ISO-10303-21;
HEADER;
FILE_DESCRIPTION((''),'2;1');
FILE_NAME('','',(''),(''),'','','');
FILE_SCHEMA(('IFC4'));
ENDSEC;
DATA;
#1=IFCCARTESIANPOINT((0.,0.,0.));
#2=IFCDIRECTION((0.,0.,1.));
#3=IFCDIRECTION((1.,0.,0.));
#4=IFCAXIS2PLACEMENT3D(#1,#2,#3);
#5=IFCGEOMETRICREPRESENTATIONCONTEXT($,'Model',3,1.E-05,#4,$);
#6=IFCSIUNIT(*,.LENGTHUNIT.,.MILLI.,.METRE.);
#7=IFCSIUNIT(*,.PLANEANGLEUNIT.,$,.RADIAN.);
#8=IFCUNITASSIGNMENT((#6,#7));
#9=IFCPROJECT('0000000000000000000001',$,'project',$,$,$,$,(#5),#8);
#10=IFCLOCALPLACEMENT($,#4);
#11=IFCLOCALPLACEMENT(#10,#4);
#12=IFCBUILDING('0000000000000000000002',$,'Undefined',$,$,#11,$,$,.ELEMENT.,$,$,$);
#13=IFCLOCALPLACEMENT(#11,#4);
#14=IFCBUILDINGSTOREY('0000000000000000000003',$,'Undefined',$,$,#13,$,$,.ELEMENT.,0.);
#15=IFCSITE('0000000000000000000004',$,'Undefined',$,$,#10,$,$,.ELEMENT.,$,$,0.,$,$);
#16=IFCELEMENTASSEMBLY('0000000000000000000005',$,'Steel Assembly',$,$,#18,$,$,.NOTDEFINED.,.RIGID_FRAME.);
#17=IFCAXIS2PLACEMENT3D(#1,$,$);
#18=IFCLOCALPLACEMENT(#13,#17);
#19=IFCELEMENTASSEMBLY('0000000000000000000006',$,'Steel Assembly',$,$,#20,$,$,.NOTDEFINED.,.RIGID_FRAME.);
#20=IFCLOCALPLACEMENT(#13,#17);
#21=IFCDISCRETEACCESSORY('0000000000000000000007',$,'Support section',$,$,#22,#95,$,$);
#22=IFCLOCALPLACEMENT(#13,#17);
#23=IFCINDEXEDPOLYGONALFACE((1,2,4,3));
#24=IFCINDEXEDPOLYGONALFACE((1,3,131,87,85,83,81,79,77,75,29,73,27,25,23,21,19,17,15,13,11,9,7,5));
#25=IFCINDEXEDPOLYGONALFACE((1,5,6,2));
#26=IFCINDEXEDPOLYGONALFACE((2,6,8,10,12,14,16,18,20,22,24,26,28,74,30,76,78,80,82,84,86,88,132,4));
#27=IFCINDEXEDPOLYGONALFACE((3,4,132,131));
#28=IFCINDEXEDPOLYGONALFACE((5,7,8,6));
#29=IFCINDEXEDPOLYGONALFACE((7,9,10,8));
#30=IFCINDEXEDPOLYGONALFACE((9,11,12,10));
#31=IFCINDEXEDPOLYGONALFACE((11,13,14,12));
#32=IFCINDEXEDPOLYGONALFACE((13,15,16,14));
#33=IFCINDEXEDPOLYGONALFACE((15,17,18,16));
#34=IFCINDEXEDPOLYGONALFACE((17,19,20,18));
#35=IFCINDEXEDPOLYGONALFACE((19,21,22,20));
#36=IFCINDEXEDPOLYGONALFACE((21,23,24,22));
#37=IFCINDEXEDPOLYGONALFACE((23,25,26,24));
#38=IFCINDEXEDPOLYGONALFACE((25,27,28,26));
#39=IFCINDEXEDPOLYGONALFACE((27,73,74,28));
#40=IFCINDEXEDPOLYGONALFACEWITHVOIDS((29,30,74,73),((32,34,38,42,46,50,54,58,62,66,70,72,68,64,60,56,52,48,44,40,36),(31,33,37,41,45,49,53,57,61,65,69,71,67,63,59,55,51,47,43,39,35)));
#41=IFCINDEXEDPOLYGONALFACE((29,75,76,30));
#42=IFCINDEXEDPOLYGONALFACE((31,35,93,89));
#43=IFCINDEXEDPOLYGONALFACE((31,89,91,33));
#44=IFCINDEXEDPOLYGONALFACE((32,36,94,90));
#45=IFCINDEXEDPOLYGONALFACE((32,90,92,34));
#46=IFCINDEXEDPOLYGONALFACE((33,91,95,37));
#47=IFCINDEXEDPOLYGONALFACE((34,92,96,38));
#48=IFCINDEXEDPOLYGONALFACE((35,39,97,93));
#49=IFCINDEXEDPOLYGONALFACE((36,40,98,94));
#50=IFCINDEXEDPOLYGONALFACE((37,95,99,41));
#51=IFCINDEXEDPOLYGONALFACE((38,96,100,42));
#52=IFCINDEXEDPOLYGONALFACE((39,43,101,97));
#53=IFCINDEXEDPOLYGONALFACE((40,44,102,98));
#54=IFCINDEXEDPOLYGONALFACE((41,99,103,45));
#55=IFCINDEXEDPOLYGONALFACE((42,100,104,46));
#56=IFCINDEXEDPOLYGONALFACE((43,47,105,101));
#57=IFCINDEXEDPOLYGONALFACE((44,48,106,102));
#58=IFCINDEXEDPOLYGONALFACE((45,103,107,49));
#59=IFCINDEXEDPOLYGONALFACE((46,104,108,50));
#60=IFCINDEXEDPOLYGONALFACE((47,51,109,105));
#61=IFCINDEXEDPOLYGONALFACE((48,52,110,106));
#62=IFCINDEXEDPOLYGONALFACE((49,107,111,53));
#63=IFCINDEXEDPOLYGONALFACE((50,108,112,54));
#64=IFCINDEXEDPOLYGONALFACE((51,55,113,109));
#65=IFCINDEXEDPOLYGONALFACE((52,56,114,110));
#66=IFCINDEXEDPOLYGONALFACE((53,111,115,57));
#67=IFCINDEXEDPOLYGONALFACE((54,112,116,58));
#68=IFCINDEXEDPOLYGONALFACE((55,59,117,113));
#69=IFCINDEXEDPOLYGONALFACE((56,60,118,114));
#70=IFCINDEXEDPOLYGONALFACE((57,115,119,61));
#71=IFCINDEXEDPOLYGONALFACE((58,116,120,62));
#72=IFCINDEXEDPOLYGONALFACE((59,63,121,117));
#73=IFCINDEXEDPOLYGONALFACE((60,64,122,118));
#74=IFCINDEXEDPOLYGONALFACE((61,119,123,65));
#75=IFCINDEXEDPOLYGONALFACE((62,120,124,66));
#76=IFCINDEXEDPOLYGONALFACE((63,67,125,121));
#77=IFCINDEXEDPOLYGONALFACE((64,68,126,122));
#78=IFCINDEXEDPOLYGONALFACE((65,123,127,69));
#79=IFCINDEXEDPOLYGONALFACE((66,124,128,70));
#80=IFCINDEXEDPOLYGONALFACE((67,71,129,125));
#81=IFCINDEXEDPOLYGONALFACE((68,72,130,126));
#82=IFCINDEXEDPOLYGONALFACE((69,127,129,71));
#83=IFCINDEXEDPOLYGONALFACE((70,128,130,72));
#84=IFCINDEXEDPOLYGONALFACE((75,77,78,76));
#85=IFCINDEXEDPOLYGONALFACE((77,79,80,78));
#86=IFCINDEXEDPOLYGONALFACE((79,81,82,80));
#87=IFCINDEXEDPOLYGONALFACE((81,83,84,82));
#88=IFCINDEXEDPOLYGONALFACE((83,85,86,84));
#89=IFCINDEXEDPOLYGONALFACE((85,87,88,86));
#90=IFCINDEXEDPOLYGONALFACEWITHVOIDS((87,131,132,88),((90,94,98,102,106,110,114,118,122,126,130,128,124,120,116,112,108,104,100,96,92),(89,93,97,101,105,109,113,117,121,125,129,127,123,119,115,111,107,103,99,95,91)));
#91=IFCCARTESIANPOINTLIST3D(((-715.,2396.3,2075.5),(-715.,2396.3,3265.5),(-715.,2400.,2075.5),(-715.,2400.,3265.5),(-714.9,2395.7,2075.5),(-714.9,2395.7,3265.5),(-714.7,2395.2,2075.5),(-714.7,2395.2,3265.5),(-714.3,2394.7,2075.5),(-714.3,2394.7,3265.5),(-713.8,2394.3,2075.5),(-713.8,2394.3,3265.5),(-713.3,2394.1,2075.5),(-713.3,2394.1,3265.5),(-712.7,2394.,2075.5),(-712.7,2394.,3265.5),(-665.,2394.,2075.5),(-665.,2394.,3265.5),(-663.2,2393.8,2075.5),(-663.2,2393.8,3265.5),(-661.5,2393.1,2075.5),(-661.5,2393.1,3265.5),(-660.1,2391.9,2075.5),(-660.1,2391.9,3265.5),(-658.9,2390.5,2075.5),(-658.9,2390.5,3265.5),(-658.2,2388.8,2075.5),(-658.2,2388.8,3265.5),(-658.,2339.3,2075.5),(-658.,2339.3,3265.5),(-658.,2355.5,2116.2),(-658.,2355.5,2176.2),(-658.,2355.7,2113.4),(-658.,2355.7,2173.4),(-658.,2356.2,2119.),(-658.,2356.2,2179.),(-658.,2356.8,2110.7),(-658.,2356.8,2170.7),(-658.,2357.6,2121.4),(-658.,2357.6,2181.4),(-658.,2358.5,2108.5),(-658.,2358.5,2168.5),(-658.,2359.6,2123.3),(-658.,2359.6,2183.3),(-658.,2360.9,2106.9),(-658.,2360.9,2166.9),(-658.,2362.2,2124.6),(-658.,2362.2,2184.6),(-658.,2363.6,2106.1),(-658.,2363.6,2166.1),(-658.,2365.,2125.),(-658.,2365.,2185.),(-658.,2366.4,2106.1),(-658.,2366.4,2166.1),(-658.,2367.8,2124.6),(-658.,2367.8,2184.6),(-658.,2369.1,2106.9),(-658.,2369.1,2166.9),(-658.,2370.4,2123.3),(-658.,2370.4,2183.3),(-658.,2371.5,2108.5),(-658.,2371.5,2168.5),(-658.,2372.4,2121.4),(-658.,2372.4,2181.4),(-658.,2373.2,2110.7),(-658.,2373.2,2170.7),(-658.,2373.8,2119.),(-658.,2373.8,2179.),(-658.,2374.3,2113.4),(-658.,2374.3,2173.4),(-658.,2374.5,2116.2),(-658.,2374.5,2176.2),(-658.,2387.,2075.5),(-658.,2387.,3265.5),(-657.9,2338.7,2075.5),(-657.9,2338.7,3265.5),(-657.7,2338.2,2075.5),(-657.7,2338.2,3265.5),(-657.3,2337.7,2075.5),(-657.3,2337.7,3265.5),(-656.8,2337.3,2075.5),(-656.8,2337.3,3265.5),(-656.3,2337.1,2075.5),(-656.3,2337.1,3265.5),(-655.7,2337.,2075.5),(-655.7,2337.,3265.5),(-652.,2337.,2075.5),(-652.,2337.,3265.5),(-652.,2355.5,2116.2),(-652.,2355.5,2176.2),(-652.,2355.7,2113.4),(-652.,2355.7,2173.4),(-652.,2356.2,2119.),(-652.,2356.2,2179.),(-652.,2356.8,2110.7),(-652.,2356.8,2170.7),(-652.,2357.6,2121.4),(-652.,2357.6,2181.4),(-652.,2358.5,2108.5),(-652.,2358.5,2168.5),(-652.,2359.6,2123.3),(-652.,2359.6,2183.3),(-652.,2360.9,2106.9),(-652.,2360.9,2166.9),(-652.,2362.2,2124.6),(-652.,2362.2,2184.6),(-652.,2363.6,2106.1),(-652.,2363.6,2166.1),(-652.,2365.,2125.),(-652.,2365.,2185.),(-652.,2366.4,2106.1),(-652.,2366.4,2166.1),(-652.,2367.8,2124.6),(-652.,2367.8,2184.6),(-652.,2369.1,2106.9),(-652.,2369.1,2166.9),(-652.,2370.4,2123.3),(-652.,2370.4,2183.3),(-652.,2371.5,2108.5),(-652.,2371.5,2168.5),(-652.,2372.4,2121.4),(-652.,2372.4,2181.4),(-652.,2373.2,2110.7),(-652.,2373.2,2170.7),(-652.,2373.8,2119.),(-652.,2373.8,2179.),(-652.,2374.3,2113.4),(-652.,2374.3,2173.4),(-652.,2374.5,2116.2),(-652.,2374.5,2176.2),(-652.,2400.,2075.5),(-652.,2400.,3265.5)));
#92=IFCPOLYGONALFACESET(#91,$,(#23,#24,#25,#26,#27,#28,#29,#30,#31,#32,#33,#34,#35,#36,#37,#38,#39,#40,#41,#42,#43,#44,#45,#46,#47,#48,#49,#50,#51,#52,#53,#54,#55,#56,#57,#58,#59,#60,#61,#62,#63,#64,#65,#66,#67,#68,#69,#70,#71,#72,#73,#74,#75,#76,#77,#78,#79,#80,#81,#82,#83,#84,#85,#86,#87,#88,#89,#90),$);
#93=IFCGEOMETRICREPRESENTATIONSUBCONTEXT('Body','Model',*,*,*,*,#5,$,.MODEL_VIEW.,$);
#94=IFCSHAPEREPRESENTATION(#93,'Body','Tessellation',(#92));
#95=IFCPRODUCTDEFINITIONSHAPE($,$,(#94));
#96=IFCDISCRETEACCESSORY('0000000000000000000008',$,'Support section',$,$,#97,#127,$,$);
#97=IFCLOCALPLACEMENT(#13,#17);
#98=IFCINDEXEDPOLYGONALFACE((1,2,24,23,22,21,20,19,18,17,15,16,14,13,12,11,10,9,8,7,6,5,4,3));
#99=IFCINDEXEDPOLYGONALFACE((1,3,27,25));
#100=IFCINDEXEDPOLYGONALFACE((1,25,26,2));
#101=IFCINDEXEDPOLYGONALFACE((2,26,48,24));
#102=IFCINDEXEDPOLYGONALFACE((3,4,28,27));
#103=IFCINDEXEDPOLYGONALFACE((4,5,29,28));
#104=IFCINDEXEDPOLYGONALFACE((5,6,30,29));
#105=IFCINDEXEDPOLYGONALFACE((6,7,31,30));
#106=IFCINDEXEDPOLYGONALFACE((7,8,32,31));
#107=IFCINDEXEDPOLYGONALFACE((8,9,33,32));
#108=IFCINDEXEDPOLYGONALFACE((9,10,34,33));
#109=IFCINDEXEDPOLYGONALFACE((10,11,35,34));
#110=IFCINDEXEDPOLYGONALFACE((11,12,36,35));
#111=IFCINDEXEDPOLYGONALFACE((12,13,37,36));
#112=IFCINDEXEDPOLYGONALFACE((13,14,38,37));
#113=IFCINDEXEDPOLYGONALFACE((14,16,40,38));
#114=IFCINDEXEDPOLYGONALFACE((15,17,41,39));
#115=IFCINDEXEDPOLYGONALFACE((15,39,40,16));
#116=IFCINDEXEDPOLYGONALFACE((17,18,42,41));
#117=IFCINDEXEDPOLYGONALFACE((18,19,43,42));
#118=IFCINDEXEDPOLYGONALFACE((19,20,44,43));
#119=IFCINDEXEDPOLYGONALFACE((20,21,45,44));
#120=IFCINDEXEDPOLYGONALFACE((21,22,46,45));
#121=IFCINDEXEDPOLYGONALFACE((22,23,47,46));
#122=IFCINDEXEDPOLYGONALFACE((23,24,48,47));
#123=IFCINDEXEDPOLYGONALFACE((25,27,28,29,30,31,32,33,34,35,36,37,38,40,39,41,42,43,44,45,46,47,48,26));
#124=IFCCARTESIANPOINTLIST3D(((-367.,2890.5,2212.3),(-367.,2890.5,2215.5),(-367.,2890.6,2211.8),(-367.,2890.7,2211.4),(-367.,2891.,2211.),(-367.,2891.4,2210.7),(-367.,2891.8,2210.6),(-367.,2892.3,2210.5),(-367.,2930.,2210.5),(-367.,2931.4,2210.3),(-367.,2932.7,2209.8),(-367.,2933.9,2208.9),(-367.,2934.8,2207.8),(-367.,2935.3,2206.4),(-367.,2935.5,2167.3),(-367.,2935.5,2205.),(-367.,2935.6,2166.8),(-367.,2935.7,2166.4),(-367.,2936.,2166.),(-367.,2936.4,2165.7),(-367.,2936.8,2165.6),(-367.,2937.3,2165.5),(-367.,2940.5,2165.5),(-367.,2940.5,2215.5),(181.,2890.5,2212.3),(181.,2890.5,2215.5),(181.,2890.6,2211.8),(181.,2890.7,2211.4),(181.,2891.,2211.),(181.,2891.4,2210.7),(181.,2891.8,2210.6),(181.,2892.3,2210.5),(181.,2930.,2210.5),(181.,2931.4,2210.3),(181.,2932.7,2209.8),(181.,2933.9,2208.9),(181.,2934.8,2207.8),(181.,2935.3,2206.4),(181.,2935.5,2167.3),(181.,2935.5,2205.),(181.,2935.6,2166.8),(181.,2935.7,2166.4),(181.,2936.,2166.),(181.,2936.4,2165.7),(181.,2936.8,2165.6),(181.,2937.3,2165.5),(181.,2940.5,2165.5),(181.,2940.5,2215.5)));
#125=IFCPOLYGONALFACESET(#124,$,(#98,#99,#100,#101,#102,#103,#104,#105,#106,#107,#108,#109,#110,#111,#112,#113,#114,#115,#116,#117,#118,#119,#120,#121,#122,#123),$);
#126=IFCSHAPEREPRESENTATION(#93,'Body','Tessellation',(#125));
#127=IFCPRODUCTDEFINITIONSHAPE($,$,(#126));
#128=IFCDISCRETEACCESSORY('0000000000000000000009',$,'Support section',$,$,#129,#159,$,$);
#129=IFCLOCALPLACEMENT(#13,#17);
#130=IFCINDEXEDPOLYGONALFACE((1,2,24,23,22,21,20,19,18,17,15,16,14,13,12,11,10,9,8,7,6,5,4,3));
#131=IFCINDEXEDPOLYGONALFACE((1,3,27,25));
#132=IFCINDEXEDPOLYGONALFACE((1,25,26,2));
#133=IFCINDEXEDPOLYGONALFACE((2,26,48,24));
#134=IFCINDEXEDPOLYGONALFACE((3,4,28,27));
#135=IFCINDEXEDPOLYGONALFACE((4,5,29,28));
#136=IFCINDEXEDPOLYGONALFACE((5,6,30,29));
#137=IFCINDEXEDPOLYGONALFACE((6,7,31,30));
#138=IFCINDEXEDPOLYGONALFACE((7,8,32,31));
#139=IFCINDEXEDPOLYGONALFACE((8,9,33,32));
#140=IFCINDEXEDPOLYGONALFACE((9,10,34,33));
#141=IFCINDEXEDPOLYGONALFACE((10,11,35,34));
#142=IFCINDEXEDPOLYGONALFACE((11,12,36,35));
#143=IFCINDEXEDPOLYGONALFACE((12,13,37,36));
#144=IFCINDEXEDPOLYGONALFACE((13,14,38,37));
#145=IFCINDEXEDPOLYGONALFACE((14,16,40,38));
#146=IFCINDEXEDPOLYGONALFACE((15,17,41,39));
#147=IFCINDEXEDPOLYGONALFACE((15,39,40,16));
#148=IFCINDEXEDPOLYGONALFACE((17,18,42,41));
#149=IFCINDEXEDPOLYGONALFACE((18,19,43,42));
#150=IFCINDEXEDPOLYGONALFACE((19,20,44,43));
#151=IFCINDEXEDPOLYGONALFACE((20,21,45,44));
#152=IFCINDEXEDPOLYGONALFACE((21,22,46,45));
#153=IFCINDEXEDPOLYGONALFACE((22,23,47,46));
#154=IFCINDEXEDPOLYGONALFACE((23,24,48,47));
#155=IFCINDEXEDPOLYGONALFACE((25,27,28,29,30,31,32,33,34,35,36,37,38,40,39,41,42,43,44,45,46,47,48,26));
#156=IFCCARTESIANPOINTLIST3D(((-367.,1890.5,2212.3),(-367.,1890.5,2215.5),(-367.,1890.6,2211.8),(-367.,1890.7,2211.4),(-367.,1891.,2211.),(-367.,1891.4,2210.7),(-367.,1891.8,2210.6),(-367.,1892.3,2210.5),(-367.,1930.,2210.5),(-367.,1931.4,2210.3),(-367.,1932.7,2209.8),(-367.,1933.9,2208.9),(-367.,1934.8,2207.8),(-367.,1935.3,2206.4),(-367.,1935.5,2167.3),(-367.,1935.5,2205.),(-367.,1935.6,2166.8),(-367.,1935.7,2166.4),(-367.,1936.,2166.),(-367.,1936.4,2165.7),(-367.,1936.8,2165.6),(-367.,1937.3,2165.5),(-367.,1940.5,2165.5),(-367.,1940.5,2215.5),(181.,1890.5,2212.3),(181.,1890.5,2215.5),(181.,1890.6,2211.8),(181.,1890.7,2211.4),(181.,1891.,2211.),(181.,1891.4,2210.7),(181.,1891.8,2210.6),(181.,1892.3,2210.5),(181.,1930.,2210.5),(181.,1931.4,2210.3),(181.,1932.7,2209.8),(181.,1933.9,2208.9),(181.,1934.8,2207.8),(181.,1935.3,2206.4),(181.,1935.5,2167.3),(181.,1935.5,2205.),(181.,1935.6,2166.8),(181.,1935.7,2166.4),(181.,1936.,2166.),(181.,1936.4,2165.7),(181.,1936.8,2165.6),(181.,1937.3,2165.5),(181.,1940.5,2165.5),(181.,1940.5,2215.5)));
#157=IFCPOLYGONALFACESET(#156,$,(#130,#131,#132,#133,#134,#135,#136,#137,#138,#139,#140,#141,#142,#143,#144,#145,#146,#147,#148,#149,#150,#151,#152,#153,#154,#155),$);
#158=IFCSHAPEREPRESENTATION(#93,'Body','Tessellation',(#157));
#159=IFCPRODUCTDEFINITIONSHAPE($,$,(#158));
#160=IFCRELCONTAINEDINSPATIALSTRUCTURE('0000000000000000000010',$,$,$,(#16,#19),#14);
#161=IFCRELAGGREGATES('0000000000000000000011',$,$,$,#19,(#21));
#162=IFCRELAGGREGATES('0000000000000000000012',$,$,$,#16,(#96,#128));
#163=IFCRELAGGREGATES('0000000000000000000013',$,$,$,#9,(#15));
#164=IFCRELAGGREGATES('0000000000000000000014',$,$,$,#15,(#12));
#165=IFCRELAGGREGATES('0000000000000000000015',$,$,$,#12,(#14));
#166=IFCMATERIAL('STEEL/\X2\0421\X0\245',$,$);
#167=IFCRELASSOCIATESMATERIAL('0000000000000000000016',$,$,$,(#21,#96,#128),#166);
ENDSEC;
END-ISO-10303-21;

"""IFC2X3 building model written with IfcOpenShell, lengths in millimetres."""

from ifc_helpers import new_model, si_unit, frame, origin_with_axes, origin_2d_with_axis, place, context, subcontext, project, spatial, circle, l_section, extrude, source, transform, mapped, material, element, aggregate, save


model = new_model("IFC2X3")

# Units and contexts
model_context = context("Model", 3, precision=1e-05, world=origin_with_axes())
body_context = subcontext(model_context, "Body", "Model", "MODEL_VIEW")
ifc_project = project(units=[si_unit("LENGTHUNIT", "METRE", prefix="MILLI"), si_unit("PLANEANGLEUNIT", "RADIAN")], contexts=[model_context])

# Site, building, storey
site_placement = place(None, origin_with_axes())
site = spatial("IfcSite", under=ifc_project, at=site_placement, Name="Undefined", CompositionType="ELEMENT", RefElevation=0.0)
building_placement = place(site_placement, origin_with_axes())
building = spatial("IfcBuilding", under=site, at=building_placement, Name="Undefined", CompositionType="ELEMENT")
storey_placement = place(building_placement, origin_with_axes())
storey = spatial("IfcBuildingStorey", under=building, at=storey_placement, Name="Undefined", CompositionType="ELEMENT", Elevation=0.0)

# Shared definitions
ifc_material_1 = material(Name="STEEL/С245")

# Element assembly
assembly_1_placement = place(storey_placement, origin_with_axes())
assembly_1 = element("IfcElementAssembly", 1, at=assembly_1_placement, inside=storey, Name="Steel Assembly", AssemblyPlace="NOTDEFINED", PredefinedType="RIGID_FRAME")

# Shared definitions
shared_shape_1 = source(origin_with_axes(), body_context, "Body", "SweptSolid", [
    extrude(circle(Radius=9.5, at=origin_2d_with_axis()), frame((0.0, -0.1, 0.0), z_axis=(0.0, 1.0, 0.0), x_axis=(1.0, 0.0, 0.0)), (0.0, 0.0, 1.0), 6.2),
])

# Element assembly, discrete accessory, opening
assembly_2_placement = place(storey_placement, origin_with_axes())
assembly_2 = element("IfcElementAssembly", 2, at=assembly_2_placement, inside=storey, Name="Steel Assembly", AssemblyPlace="NOTDEFINED", PredefinedType="RIGID_FRAME")
discrete_accessory_1_placement = place(assembly_2_placement, frame((-683.5, 2368.5, 2075.5), z_axis=(0.0, 0.0, 1.0), x_axis=(1.0, 0.0, 0.0)))
discrete_accessory_1 = element("IfcDiscreteAccessory", 3, at=discrete_accessory_1_placement, material=ifc_material_1, Name="Support section", context=body_context, shape_type="SweptSolid", body=[
    extrude(l_section(Depth=63.0, Width=63.0, Thickness=6.0, FilletRadius=7.0, EdgeRadius=2.3, at=origin_2d_with_axis()), frame((0.0, 0.0, 1190.0), z_axis=(0.0, 0.0, -1.0), x_axis=(0.0, -1.0, 0.0)), (0.0, 0.0, 1.0), 1190.0),
])
opening_1_placement = place(assembly_2_placement, frame((-652.0, 2365.0, 2115.5), z_axis=(0.0, -1.0, 0.0), x_axis=(0.0, 0.0, 1.0)))
element("IfcOpeningElement", 4, at=opening_1_placement, cuts=discrete_accessory_1, ObjectType="Opening", context=body_context, shape_type="MappedRepresentation", body=[
    mapped(shared_shape_1, transform((0.0, 0.0, 0.0))),
    mapped(shared_shape_1, transform((60.0, 0.0, 0.0))),
])
aggregate(assembly_2, [discrete_accessory_1])

# Discrete accessories
discrete_accessory_2_placement = place(assembly_1_placement, frame((-367.0, 2915.5, 2190.5), z_axis=(0.0, -1.0, 0.0), x_axis=(1.0, 0.0, 0.0)))
discrete_accessory_2 = element("IfcDiscreteAccessory", 5, at=discrete_accessory_2_placement, material=ifc_material_1, Name="Support section", context=body_context, shape_type="SweptSolid", body=[
    extrude(l_section(Depth=50.0, Width=50.0, Thickness=5.0, FilletRadius=5.5, EdgeRadius=1.8, at=origin_2d_with_axis()), frame((548.0, 0.0, 0.0), z_axis=(-1.0, 0.0, 0.0), x_axis=(0.0, -1.0, 0.0)), (0.0, 0.0, 1.0), 548.0),
])
discrete_accessory_3_placement = place(assembly_1_placement, frame((-367.0, 1915.5, 2190.5), z_axis=(0.0, -1.0, 0.0), x_axis=(1.0, 0.0, 0.0)))
discrete_accessory_3 = element("IfcDiscreteAccessory", 6, at=discrete_accessory_3_placement, material=ifc_material_1, Name="Support section", context=body_context, shape_type="SweptSolid", body=[
    extrude(l_section(Depth=50.0, Width=50.0, Thickness=5.0, FilletRadius=5.5, EdgeRadius=1.8, at=origin_2d_with_axis()), frame((548.0, 0.0, 0.0), z_axis=(-1.0, 0.0, 0.0), x_axis=(0.0, -1.0, 0.0)), (0.0, 0.0, 1.0), 548.0),
])
aggregate(assembly_1, [discrete_accessory_2, discrete_accessory_3])

save(model, "model.ifc")
